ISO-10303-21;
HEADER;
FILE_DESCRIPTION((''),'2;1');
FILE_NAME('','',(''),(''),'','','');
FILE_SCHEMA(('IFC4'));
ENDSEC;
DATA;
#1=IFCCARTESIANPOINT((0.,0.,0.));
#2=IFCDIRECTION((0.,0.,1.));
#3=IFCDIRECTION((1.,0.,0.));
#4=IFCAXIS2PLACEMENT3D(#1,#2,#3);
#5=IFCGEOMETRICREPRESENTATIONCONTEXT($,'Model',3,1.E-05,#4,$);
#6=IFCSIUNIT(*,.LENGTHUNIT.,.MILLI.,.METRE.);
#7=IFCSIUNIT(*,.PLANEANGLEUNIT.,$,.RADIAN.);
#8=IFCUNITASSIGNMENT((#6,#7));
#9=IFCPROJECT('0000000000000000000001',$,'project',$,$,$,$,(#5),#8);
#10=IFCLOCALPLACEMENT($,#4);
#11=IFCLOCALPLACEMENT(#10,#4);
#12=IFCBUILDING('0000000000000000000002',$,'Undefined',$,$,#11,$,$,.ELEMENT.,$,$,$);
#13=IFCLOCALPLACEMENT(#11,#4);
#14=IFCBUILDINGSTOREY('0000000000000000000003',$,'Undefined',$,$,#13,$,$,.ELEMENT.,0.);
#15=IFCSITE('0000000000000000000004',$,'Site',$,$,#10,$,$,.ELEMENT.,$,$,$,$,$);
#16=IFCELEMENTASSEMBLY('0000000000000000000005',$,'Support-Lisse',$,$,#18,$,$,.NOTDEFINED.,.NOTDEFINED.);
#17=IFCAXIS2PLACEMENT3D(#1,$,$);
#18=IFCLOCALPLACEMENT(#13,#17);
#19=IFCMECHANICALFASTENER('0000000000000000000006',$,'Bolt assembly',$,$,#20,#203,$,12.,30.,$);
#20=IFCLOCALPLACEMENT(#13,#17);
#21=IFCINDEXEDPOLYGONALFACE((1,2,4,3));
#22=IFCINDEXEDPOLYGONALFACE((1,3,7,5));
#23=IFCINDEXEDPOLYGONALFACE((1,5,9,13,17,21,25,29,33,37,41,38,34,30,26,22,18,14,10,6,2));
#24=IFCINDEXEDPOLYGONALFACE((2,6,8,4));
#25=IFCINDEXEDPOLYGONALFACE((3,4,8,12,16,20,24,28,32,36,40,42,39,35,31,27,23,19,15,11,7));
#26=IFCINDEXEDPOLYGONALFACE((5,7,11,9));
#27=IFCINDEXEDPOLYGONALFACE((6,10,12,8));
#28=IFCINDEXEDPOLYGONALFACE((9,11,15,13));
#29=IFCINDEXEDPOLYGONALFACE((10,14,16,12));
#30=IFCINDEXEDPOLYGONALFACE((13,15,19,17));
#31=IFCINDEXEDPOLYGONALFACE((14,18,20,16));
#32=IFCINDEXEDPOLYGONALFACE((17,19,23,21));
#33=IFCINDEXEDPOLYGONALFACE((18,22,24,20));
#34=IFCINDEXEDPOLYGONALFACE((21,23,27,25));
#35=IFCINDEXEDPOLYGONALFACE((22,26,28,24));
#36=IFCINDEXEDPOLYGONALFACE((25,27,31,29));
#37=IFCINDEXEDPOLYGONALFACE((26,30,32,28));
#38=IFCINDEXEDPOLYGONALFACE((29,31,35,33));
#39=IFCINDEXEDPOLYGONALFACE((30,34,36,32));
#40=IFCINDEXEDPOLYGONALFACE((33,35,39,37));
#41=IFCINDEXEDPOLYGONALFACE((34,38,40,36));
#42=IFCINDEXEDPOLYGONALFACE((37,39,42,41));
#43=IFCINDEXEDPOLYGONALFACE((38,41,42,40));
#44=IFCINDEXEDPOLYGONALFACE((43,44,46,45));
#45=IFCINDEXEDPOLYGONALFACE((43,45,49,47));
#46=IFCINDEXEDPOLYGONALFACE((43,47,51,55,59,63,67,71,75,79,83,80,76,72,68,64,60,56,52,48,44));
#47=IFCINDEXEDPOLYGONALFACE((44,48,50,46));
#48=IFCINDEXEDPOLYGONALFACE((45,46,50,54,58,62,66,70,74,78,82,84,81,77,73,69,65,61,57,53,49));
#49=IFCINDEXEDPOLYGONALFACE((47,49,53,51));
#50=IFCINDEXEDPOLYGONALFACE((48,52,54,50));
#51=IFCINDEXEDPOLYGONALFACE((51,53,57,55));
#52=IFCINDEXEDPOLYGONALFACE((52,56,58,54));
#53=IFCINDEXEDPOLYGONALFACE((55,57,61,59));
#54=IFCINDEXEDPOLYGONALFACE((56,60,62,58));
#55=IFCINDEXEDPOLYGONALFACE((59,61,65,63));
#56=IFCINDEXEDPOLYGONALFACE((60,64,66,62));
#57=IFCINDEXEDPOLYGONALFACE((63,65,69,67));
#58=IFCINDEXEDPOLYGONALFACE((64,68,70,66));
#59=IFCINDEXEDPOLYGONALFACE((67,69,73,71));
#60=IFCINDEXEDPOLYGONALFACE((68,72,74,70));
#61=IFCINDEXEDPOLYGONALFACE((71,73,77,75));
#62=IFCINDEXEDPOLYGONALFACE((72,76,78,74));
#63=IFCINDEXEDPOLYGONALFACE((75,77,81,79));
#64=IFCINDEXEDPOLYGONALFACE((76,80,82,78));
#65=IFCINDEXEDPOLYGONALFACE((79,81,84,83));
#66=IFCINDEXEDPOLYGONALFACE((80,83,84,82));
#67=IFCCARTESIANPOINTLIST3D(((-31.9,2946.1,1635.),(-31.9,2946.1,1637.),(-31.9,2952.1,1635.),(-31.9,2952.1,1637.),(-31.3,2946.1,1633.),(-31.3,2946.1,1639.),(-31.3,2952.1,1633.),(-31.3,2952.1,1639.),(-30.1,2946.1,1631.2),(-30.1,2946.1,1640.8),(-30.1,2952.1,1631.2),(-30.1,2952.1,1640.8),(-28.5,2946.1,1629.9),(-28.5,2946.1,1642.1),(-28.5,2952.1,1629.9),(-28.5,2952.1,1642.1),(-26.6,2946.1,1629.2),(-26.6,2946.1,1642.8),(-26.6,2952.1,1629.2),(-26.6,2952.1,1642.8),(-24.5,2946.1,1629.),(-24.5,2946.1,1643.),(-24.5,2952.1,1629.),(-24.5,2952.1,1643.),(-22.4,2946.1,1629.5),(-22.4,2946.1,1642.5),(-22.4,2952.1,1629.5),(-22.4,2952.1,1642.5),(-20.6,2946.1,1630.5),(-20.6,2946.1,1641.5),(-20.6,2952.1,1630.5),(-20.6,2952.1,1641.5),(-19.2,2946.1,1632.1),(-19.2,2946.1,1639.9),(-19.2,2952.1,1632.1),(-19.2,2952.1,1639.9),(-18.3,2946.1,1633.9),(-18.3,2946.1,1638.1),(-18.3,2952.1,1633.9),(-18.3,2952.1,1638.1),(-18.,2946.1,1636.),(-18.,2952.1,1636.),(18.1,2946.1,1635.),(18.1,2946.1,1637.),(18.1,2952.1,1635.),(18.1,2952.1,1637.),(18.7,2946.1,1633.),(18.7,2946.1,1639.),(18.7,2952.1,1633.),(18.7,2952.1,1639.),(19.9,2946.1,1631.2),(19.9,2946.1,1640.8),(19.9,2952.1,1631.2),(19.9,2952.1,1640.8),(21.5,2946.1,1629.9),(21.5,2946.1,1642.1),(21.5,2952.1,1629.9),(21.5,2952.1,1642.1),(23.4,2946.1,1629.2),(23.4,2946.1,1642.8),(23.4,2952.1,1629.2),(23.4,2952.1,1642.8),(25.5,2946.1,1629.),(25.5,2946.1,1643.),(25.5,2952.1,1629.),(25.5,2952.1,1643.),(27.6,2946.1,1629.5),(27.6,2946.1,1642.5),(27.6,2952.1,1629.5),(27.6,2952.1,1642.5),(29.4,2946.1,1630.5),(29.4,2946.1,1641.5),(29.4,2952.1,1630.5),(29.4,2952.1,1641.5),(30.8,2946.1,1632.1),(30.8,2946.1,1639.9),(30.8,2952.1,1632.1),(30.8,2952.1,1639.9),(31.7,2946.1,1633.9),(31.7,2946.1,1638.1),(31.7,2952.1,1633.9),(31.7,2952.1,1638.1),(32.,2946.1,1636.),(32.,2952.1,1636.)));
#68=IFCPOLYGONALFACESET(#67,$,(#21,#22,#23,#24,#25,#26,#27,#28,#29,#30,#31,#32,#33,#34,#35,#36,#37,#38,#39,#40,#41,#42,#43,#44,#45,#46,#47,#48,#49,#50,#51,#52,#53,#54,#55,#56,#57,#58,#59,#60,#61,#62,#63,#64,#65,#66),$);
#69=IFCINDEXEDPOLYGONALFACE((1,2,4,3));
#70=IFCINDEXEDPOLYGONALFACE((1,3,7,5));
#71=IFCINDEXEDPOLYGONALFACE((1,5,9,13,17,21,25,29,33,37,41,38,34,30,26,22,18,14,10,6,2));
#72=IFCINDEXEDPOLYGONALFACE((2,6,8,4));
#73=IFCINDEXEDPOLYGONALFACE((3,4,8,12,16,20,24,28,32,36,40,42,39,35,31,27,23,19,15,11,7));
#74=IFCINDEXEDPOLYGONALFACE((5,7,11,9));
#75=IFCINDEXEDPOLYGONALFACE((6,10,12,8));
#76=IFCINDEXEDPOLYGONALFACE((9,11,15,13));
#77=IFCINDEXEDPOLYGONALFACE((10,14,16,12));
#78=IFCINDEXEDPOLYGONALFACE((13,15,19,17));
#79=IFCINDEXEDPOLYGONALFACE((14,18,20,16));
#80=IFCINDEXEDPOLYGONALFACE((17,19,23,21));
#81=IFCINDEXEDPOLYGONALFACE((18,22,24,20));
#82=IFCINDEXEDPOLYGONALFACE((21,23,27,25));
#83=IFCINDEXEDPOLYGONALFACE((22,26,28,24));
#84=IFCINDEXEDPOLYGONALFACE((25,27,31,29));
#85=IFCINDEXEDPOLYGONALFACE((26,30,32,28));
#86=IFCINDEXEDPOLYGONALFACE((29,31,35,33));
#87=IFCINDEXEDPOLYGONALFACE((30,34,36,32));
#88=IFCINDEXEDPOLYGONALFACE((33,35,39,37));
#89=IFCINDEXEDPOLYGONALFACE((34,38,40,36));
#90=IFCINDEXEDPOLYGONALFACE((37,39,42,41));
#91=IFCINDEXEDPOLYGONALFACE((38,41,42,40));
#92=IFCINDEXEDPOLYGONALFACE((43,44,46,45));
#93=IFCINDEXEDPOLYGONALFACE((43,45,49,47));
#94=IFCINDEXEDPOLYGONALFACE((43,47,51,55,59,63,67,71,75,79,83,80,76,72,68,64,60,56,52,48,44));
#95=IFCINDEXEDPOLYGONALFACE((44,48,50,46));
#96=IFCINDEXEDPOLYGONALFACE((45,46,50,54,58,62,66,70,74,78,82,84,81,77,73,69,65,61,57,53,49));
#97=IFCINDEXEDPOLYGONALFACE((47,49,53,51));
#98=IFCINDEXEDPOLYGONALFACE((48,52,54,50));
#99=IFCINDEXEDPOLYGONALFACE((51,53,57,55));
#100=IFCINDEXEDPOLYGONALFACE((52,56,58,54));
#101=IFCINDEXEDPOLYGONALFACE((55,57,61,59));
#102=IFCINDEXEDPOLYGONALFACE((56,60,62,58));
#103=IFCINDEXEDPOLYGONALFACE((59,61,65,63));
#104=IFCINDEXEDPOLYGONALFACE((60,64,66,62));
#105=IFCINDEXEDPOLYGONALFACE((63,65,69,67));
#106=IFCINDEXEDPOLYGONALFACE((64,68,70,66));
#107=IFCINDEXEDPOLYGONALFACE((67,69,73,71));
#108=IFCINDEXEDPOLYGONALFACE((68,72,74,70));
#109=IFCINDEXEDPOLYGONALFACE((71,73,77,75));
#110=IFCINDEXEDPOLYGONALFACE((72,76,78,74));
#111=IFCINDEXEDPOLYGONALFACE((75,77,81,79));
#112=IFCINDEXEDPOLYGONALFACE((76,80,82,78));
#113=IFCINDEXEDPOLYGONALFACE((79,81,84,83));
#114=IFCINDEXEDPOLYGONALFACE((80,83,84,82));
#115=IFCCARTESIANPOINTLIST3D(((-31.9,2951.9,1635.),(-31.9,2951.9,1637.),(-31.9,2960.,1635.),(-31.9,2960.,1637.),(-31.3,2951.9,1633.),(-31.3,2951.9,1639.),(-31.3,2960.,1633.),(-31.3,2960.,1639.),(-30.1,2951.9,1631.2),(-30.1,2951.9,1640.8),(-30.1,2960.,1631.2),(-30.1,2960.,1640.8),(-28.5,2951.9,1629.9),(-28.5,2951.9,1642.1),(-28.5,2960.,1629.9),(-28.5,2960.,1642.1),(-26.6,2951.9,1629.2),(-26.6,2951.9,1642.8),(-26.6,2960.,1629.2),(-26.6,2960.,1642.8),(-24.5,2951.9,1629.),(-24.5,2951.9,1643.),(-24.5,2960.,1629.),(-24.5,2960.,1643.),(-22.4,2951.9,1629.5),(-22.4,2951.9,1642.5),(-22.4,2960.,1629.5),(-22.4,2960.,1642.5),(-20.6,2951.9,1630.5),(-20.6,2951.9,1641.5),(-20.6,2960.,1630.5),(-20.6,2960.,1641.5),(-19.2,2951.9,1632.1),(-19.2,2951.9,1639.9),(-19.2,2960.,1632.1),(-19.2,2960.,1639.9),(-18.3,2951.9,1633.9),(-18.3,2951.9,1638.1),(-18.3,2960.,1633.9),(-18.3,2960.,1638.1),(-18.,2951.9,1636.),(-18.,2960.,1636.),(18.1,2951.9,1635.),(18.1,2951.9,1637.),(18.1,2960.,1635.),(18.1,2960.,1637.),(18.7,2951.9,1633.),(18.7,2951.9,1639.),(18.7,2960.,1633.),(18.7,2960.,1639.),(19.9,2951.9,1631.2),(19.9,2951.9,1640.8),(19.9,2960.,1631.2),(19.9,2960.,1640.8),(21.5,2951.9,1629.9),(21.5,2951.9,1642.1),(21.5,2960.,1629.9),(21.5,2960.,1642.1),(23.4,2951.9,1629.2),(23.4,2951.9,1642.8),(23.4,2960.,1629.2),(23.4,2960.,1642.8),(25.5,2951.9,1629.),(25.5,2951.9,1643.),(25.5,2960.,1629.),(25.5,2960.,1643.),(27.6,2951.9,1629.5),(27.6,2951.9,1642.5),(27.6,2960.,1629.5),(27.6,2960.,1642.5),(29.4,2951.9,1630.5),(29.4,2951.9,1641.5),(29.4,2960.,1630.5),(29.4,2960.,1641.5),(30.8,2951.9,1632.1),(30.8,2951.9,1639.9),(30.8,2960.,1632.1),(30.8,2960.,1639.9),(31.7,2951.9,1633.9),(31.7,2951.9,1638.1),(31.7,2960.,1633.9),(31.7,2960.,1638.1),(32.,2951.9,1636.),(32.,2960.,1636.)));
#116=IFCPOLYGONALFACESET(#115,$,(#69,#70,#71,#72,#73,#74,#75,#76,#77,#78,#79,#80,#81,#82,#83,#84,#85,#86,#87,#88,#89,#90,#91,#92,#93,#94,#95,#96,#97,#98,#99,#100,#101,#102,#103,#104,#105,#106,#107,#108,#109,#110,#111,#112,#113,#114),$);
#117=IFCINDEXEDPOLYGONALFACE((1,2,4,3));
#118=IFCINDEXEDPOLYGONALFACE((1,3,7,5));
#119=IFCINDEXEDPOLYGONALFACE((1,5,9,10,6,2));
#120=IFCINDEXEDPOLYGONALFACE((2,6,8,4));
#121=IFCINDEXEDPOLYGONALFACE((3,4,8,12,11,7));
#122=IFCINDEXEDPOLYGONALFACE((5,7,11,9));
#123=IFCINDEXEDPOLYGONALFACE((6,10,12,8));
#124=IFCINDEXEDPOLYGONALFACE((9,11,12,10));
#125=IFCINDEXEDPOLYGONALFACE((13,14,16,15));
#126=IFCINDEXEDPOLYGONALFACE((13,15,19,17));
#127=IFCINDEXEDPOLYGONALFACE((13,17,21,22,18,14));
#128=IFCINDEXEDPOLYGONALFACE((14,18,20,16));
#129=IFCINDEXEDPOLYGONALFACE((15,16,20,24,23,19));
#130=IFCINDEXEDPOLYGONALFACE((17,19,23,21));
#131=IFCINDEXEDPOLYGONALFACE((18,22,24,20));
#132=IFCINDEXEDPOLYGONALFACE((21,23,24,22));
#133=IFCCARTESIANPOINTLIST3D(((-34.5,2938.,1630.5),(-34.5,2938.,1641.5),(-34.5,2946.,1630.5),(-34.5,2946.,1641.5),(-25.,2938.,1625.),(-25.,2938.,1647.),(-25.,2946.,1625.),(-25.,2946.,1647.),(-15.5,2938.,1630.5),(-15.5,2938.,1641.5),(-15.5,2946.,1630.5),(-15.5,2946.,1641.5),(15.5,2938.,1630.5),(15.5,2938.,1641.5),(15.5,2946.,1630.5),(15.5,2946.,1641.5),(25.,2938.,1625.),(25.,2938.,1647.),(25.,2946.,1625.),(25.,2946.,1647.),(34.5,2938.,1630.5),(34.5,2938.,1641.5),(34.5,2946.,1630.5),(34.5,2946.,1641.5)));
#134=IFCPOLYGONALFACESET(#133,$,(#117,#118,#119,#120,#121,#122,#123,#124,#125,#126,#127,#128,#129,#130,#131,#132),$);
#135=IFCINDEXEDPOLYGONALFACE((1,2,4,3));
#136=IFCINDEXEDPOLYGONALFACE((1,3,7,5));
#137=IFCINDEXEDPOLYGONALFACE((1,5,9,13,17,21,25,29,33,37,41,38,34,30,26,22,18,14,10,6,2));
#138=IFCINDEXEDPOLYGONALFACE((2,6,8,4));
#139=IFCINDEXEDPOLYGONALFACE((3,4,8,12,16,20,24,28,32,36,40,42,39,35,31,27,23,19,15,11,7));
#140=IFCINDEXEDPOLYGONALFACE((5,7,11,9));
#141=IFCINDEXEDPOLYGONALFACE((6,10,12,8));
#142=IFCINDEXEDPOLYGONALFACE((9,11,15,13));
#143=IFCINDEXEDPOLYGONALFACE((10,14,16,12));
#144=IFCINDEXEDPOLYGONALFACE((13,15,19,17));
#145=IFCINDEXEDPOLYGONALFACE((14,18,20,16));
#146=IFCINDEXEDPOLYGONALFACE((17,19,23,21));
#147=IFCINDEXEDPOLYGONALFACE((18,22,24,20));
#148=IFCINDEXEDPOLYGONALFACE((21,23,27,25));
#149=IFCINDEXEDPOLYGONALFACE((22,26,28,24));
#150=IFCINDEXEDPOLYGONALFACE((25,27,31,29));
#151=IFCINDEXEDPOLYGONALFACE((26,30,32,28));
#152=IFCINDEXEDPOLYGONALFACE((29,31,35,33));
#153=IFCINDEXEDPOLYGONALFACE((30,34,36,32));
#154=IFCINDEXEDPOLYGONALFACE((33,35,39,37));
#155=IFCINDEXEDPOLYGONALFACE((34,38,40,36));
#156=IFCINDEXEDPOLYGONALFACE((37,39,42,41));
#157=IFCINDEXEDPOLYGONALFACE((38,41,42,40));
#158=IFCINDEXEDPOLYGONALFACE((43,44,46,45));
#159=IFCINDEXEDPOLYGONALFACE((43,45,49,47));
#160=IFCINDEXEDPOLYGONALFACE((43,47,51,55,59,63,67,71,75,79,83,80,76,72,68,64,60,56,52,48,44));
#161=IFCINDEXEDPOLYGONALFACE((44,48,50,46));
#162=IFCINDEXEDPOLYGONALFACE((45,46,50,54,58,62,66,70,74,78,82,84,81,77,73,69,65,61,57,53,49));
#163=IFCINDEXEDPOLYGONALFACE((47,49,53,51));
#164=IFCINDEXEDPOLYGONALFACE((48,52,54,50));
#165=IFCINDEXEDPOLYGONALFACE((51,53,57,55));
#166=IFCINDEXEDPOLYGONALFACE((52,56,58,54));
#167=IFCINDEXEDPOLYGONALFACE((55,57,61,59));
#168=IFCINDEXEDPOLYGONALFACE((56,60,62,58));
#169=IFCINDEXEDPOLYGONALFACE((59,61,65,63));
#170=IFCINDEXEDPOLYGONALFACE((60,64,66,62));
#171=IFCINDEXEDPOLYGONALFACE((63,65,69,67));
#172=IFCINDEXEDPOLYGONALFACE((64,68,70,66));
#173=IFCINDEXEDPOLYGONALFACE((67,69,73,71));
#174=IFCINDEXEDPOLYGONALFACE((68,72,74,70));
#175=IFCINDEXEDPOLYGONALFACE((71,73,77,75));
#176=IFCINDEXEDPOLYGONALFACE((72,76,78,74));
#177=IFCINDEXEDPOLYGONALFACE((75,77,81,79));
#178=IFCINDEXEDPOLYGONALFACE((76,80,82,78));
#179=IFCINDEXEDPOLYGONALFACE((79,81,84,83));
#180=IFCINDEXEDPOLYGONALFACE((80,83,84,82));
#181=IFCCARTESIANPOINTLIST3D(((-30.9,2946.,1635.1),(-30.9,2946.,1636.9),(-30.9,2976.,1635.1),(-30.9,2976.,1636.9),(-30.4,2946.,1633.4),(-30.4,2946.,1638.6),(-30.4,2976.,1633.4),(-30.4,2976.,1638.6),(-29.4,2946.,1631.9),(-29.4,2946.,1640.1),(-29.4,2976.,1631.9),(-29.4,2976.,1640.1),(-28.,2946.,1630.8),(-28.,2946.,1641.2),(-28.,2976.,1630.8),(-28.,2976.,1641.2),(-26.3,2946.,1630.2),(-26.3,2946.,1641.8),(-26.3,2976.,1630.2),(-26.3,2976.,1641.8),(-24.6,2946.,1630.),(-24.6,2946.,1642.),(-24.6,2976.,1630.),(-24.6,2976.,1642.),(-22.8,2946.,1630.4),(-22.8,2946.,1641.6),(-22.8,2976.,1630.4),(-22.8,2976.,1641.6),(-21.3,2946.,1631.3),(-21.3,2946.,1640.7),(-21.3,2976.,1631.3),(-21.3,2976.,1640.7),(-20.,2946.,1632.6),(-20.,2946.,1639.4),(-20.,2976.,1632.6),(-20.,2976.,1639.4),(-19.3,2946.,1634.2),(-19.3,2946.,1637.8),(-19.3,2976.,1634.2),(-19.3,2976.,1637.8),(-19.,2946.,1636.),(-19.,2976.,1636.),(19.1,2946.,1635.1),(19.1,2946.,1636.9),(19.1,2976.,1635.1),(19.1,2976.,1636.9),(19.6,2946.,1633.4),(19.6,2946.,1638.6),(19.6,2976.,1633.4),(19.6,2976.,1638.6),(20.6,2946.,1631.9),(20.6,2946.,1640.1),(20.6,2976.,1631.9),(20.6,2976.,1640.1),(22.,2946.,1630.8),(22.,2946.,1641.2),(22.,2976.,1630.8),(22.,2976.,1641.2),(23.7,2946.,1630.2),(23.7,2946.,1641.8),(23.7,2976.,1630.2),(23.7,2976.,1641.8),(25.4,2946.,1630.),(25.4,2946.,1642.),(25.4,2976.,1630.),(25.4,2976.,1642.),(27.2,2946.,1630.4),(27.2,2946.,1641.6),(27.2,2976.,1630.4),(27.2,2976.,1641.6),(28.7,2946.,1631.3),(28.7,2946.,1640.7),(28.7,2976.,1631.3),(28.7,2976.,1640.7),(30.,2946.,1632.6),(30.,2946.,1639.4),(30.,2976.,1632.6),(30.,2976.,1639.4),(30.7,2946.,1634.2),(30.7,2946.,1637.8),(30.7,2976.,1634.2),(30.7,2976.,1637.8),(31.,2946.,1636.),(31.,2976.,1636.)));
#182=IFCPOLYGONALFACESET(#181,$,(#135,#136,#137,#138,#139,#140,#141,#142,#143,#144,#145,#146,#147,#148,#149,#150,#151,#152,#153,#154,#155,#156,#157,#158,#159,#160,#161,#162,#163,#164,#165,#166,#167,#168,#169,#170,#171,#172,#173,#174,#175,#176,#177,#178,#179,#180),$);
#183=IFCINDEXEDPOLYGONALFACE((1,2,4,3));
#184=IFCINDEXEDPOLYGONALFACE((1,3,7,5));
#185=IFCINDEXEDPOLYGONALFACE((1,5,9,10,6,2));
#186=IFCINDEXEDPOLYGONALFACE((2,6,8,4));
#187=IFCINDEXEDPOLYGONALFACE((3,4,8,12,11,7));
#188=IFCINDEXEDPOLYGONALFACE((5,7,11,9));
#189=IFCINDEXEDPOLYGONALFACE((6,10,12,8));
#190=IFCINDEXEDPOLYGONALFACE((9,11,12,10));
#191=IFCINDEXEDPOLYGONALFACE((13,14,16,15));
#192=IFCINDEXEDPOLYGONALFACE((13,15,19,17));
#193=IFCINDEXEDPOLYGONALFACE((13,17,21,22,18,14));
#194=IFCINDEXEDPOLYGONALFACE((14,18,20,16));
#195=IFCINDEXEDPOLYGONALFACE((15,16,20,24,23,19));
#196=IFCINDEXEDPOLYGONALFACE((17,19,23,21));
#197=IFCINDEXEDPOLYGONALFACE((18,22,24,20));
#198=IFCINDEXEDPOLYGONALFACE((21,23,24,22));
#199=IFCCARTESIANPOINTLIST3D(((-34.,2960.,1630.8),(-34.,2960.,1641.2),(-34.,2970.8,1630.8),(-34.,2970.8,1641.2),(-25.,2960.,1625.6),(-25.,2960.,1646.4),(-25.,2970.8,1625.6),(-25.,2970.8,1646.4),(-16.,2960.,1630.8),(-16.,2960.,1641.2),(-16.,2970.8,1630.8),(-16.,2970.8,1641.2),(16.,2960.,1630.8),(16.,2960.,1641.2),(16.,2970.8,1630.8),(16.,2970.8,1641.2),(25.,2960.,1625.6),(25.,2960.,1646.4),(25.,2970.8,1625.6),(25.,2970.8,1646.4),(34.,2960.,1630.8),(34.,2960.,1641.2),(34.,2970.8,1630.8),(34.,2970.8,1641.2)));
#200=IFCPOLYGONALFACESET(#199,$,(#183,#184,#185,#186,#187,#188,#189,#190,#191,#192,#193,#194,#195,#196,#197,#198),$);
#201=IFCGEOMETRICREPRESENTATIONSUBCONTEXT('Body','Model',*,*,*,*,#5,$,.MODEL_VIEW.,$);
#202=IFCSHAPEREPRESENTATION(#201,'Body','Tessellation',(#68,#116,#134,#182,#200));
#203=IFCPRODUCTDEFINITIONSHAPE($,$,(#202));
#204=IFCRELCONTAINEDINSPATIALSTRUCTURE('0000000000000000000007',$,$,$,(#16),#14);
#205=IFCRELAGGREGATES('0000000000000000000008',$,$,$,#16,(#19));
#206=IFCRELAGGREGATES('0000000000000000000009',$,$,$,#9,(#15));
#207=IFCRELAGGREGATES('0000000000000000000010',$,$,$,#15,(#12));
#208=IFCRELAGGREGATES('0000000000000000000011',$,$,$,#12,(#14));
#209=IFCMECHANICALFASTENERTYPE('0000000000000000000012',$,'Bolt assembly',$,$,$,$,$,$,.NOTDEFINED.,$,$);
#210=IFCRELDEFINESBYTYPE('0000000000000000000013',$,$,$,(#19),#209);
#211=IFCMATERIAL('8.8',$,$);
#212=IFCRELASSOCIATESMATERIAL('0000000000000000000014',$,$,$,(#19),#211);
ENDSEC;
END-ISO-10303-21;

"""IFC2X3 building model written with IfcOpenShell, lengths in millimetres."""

from ifc_helpers import new_model, si_unit, frame, origin_with_axes, origin_2d_with_axis, place, context, subcontext, project, spatial, polyline, circle, outline, extrude, source, transform, mapped, material, type_object, element, aggregate, save


model = new_model("IFC2X3")

# Units and contexts
model_context = context("Model", 3, precision=1e-05, world=origin_with_axes())
body_context = subcontext(model_context, "Body", "Model", "MODEL_VIEW")
ifc_project = project(units=[si_unit("LENGTHUNIT", "METRE", prefix="MILLI"), si_unit("PLANEANGLEUNIT", "RADIAN")], contexts=[model_context])

# Site, building, storey
site_placement = place(None, origin_with_axes())
site = spatial("IfcSite", under=ifc_project, at=site_placement, Name="Site", CompositionType="ELEMENT")
building_placement = place(site_placement, origin_with_axes())
building = spatial("IfcBuilding", under=site, at=building_placement, Name="Undefined", CompositionType="ELEMENT")
storey_placement = place(building_placement, origin_with_axes())
storey = spatial("IfcBuildingStorey", under=building, at=storey_placement, Name="Undefined", CompositionType="ELEMENT", Elevation=0.0)

# Shared definitions
mechanical_fastener_type = type_object("IfcMechanicalFastenerType", Name="Bolt assembly")
ifc_material_1 = material(Name="8.8")

# Element assembly
assembly_1_placement = place(storey_placement, origin_with_axes())
assembly_1 = element("IfcElementAssembly", 1, at=assembly_1_placement, inside=storey, Name="Support-Lisse", AssemblyPlace="NOTDEFINED", PredefinedType="NOTDEFINED")

# Mechanical fastener
shared_shape_1 = source(origin_with_axes(), body_context, "Body", "SweptSolid", [
    extrude(circle(Radius=7.0, at=origin_2d_with_axis()), frame((0.0, -5.9, 0.0), z_axis=(0.0, 1.0, 0.0), x_axis=(1.0, 0.0, 0.0)), (0.0, 0.0, 1.0), 6.0),
    extrude(circle(Radius=7.0, at=origin_2d_with_axis()), frame((0.0, -0.1, 0.0), z_axis=(0.0, 1.0, 0.0), x_axis=(1.0, 0.0, 0.0)), (0.0, 0.0, 1.0), 8.1),
    extrude(outline(polyline([(9.5, -5.5), (9.5, 5.5), (0.0, 11.0), (-9.5, 5.5), (-9.5, -5.5), (0.0, -11.0), (9.5, -5.5)])), frame((0.0, -14.0, 0.0), z_axis=(0.0, 1.0, 0.0), x_axis=(1.0, 0.0, 0.0)), (0.0, 0.0, 1.0), 8.0),
    extrude(circle(Radius=6.0, at=origin_2d_with_axis()), frame((0.0, -6.0, 0.0), z_axis=(0.0, 1.0, 0.0), x_axis=(1.0, 0.0, 0.0)), (0.0, 0.0, 1.0), 30.0),
    extrude(outline(polyline([(9.0, -5.2), (9.0, 5.2), (0.0, 10.4), (-9.0, 5.2), (-9.0, -5.2), (0.0, -10.4), (9.0, -5.2)])), frame((0.0, 8.0, 0.0), z_axis=(0.0, 1.0, 0.0), x_axis=(1.0, 0.0, 0.0)), (0.0, 0.0, 1.0), 10.8),
])
mechanical_fastener_1_placement = place(assembly_1_placement, frame((-25.0, 2952.0, 1636.0), z_axis=(0.0, 0.0, 1.0), x_axis=(1.0, 0.0, 0.0)))
mechanical_fastener_1 = element("IfcMechanicalFastener", 2, at=mechanical_fastener_1_placement, type_object=mechanical_fastener_type, material=ifc_material_1, Name="Bolt assembly", NominalDiameter=12.0, NominalLength=30.0, context=body_context, shape_type="MappedRepresentation", body=[
    mapped(shared_shape_1, transform((0.0, 0.0, 0.0))),
    mapped(shared_shape_1, transform((50.0, 0.0, 0.0))),
])
aggregate(assembly_1, [mechanical_fastener_1])

save(model, "model.ifc")
